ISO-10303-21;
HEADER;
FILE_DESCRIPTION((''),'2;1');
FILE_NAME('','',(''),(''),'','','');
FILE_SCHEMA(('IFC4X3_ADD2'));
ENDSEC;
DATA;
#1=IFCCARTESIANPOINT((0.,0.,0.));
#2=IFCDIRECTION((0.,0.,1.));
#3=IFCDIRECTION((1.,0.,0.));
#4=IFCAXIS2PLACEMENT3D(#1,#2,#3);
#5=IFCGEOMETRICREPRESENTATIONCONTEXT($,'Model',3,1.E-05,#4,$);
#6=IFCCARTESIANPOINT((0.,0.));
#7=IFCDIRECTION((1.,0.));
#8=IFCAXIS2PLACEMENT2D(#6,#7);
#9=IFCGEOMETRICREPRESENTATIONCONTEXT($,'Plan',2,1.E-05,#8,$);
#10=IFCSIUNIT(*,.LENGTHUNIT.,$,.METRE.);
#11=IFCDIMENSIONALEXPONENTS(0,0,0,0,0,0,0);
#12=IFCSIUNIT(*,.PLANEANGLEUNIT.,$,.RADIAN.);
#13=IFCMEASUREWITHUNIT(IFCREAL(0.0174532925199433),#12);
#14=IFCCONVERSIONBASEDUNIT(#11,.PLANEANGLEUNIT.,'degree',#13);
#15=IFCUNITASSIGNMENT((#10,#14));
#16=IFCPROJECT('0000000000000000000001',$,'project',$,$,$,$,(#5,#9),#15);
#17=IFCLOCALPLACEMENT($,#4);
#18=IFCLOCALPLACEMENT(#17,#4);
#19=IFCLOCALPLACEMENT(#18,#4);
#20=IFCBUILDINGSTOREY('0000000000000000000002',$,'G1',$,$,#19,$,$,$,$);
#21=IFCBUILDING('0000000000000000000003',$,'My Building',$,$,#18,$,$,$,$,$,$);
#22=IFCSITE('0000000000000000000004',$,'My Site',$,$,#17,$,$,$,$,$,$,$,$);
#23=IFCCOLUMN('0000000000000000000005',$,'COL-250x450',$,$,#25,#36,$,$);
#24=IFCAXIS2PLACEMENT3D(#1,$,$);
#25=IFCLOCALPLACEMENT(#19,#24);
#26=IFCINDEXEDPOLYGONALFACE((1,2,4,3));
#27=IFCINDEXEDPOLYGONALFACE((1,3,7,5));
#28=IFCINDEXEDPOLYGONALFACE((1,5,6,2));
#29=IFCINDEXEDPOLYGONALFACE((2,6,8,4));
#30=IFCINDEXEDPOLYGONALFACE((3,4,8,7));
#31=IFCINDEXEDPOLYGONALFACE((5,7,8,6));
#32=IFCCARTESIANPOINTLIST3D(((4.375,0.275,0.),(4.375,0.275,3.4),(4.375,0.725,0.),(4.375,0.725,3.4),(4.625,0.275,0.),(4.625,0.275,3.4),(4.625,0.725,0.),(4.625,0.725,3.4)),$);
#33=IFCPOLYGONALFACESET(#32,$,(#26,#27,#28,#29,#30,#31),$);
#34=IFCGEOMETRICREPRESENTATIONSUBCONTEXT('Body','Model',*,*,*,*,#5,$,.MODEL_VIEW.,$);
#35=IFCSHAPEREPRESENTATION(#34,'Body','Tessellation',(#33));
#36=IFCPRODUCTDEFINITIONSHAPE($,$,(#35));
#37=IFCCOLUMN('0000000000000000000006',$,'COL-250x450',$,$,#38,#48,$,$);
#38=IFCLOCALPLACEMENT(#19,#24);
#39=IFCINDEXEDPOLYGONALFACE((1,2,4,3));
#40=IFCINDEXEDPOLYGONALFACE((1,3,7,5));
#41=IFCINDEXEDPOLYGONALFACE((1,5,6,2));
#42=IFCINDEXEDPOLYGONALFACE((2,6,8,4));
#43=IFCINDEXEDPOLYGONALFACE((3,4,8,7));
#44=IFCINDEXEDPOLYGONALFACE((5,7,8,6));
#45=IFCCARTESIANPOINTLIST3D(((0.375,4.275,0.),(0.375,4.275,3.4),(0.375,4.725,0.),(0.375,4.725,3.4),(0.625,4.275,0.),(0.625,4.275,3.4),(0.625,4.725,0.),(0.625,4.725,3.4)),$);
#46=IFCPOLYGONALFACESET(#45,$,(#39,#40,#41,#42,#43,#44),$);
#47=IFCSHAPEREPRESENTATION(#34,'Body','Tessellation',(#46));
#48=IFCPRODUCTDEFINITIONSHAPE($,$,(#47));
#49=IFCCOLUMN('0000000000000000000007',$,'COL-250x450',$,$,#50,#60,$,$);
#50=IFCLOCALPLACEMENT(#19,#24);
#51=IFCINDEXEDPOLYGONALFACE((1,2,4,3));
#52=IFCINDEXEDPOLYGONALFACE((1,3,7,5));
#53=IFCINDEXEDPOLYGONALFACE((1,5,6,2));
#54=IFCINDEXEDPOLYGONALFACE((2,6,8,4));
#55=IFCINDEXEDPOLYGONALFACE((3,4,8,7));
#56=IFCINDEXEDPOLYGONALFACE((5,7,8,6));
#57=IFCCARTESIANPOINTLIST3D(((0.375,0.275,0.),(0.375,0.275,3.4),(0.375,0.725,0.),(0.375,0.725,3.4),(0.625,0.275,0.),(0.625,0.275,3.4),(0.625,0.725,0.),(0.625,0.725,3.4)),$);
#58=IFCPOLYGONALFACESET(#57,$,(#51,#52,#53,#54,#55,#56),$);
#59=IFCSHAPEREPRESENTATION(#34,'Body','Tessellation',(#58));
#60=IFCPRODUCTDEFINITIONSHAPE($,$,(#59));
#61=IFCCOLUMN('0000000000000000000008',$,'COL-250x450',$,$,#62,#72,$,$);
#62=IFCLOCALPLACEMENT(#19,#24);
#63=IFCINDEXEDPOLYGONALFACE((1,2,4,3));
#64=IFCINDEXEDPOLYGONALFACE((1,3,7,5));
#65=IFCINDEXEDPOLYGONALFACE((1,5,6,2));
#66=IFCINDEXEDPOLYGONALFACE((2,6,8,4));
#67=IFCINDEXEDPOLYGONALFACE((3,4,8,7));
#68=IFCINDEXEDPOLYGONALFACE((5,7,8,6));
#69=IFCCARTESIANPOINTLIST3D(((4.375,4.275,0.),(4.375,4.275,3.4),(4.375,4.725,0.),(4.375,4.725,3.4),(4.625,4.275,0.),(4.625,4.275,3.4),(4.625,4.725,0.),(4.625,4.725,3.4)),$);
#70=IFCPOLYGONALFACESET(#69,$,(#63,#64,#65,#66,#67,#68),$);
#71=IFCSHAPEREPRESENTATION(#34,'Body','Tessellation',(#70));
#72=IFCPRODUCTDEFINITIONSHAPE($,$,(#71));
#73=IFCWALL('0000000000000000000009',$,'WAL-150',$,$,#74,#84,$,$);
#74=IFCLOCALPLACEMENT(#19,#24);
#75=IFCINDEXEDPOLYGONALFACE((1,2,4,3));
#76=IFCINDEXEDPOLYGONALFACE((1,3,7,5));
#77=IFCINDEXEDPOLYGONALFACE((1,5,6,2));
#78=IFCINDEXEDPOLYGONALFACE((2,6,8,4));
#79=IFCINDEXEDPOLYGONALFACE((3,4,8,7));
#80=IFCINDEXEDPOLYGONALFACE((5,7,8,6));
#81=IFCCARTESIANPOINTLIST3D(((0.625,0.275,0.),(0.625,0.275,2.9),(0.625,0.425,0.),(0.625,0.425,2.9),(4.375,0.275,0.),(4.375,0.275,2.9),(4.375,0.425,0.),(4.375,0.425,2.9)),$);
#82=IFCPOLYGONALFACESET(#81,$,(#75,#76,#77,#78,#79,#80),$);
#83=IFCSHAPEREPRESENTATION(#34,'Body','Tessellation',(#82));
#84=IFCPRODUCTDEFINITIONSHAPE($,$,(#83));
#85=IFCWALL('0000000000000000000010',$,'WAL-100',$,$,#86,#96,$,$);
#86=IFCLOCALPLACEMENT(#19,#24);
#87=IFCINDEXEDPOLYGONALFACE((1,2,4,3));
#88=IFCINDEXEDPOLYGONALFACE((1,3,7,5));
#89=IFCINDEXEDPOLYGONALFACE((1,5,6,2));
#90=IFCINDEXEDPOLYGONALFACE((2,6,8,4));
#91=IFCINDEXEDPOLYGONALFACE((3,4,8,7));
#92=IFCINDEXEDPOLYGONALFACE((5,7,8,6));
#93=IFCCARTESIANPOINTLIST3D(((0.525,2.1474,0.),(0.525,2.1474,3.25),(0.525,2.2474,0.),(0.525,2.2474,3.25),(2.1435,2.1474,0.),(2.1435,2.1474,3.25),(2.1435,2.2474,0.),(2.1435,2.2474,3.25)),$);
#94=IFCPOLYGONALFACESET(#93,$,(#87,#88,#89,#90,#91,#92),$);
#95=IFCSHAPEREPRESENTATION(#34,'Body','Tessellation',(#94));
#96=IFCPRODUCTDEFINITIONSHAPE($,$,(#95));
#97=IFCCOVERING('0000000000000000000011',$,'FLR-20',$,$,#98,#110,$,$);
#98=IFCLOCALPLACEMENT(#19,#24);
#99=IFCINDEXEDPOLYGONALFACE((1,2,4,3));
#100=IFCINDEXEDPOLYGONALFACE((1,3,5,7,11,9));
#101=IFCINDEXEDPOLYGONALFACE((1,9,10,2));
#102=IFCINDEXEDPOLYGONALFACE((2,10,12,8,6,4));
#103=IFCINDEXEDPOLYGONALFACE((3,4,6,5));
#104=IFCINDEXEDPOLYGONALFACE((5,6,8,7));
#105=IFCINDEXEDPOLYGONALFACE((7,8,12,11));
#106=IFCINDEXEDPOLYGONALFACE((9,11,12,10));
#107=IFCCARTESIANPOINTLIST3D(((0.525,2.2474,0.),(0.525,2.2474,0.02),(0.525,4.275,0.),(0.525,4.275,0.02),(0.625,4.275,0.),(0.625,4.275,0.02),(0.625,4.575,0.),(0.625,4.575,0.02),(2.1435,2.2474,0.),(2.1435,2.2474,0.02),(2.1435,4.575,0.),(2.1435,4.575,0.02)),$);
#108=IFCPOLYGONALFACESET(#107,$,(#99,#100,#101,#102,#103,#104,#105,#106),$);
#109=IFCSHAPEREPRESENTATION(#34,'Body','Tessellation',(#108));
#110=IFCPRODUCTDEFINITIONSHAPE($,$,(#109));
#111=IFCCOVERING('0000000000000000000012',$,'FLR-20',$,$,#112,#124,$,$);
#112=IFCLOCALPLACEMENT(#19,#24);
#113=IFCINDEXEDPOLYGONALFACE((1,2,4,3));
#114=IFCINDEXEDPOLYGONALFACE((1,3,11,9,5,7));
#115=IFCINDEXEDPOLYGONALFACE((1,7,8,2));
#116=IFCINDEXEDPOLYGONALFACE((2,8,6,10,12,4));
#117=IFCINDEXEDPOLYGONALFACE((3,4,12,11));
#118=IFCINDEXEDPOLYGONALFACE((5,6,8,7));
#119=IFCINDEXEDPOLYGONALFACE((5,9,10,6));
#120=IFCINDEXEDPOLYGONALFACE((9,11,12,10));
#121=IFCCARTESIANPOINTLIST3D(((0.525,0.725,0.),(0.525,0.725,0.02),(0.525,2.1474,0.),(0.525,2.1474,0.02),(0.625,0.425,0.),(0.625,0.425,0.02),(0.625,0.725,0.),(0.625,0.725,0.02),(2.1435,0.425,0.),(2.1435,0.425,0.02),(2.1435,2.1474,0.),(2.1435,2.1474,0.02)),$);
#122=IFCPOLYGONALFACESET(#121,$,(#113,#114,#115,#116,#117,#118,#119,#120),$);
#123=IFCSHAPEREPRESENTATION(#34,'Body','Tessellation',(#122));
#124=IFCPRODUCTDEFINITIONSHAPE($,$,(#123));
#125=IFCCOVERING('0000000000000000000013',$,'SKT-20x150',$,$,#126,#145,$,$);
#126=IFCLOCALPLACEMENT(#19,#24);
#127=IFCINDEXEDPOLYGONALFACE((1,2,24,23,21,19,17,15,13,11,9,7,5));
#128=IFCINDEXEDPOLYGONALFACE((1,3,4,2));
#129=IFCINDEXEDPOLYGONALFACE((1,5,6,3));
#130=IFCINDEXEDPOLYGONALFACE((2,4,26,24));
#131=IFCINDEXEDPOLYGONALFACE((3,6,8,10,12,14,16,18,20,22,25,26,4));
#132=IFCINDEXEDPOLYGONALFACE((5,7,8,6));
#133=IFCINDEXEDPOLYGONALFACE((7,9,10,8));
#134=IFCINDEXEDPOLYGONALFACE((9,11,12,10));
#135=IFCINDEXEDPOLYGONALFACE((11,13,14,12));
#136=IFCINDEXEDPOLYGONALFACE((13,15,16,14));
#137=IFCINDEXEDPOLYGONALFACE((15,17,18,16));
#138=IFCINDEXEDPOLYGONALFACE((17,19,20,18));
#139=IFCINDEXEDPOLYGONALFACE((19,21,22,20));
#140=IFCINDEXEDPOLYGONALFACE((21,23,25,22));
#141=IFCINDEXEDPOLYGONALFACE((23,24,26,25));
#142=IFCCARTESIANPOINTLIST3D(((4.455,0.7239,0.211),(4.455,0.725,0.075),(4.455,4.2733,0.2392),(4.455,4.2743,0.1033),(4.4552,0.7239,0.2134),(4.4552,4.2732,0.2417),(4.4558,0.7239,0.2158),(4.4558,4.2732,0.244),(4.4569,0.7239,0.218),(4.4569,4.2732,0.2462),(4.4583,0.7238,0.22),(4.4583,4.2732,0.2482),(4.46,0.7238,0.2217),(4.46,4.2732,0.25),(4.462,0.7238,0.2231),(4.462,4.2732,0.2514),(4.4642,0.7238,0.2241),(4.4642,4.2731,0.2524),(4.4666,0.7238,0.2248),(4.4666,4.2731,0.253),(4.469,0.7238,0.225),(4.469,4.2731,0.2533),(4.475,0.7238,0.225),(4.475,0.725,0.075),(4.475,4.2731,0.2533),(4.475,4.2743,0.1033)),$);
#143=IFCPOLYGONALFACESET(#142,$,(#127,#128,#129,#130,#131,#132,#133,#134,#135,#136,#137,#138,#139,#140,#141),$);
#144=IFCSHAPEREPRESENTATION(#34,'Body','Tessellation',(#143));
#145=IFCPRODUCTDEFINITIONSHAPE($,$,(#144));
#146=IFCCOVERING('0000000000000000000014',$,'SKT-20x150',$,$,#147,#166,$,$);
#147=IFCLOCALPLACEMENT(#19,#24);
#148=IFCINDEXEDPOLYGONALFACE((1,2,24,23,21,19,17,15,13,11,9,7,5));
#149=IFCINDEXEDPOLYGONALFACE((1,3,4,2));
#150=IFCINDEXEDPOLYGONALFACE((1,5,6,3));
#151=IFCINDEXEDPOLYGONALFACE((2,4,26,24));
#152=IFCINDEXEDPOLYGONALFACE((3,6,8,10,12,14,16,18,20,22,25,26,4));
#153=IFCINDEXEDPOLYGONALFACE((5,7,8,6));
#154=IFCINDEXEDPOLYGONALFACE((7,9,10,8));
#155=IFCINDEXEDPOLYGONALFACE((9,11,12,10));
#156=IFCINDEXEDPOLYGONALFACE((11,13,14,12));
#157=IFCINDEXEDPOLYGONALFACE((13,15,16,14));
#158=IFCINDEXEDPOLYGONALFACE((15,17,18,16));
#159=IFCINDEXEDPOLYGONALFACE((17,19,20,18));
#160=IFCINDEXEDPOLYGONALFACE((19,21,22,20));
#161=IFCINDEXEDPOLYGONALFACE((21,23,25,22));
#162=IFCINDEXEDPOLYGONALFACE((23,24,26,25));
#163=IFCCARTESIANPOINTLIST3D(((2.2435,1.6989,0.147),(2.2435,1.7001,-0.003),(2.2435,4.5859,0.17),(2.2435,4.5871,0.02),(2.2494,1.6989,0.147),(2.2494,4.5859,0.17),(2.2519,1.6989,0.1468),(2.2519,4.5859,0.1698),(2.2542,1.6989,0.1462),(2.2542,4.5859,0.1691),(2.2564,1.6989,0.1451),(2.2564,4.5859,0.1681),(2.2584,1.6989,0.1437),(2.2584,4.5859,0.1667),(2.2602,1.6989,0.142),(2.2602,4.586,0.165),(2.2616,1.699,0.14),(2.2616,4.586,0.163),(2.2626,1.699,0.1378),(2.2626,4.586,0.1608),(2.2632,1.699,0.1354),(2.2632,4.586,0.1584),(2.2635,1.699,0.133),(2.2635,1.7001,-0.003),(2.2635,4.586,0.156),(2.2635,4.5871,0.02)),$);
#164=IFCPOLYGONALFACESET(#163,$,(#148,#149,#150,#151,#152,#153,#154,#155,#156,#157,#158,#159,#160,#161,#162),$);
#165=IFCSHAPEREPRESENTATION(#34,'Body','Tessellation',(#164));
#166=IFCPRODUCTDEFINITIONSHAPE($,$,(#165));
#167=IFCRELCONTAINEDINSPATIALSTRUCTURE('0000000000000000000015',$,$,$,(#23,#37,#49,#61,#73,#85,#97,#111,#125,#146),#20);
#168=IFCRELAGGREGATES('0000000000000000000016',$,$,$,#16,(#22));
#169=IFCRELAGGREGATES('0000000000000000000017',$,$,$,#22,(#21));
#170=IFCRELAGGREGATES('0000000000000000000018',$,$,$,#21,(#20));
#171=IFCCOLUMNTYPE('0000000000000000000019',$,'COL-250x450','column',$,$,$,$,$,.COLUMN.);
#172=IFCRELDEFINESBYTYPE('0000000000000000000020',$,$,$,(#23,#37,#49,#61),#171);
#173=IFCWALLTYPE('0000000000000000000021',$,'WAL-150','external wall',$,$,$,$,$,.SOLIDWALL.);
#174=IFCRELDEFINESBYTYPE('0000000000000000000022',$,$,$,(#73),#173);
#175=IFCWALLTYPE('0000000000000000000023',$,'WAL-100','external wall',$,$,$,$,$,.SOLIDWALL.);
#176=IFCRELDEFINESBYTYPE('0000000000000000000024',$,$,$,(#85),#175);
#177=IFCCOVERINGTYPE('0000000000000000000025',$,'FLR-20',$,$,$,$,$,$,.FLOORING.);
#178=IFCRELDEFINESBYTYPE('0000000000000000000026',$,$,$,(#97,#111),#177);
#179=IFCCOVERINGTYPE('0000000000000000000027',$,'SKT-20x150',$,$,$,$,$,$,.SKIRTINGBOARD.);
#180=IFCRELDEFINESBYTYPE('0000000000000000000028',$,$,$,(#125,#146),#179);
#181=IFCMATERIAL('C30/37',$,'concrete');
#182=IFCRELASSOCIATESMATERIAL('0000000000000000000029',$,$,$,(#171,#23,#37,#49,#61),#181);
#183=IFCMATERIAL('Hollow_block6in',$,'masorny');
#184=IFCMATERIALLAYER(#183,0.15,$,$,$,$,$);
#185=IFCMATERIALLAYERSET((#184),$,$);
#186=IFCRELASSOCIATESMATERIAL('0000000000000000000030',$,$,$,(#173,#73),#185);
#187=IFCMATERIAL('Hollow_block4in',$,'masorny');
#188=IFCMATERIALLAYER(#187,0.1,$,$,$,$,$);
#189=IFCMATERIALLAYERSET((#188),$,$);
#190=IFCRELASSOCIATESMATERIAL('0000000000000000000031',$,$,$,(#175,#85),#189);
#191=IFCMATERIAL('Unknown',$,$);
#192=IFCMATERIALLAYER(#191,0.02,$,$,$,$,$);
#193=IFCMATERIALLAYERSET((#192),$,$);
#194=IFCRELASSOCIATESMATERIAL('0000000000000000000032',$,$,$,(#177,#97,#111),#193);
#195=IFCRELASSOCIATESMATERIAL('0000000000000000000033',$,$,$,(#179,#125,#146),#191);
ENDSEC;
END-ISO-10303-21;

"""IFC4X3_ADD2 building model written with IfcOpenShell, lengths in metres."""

from ifc_helpers import new_model, entity, si_unit, converted_unit, frame, origin_with_axes, origin_2d_with_axis, place, context, subcontext, project, spatial, line, indexed_curve, rectangle, outline, extrude, material, layer, layer_set, layer_usage, material_profile, profile_set, profile_usage, type_object, element, save


model = new_model("IFC4X3_ADD2")

# Units and contexts
model_context = context("Model", 3, precision=1e-05, world=origin_with_axes())
plan_context = context("Plan", 2, precision=1e-05, world=origin_2d_with_axis())
body_context = subcontext(model_context, "Body", "Model", "MODEL_VIEW")
ifc_project = project(units=[si_unit("LENGTHUNIT", "METRE"), converted_unit("PLANEANGLEUNIT", "degree", entity("IfcReal", 0.0174532925199433), si_unit("PLANEANGLEUNIT", "RADIAN"), dimensions=[0, 0, 0, 0, 0, 0, 0])], contexts=[model_context, plan_context])

# Site, building, storey
site_placement = place(None, origin_with_axes())
site = spatial("IfcSite", under=ifc_project, at=site_placement, Name="My Site")
building_placement = place(site_placement, origin_with_axes())
building = spatial("IfcBuilding", under=site, at=building_placement, Name="My Building")
storey_placement = place(building_placement, origin_with_axes())
storey = spatial("IfcBuildingStorey", under=building, at=storey_placement, Name="G1")

# Columns
ifc_material_1 = material(Name="C30/37", Category="concrete")
ifc_material_profile_1 = material_profile(ifc_material_1, rectangle(XDim=0.25, YDim=0.45))
ifc_profile_set_1 = profile_set([ifc_material_profile_1])
ifc_profile_usage_1 = profile_usage(ifc_profile_set_1, cardinal=2)
column_type = type_object("IfcColumnType", Name="COL-250x450", Description="column", PredefinedType="COLUMN", material=ifc_profile_set_1)
column_1_placement = place(storey_placement, frame((4.5, 0.275, 0.0), z_axis=(0.0, 0.0, 1.0), x_axis=(1.0, 0.0, 0.0)))
element("IfcColumn", 1, at=column_1_placement, inside=storey, type_object=column_type, material=ifc_profile_usage_1, Name="COL-250x450", context=body_context, shape_type="SweptSolid", body=[
    extrude(rectangle(XDim=0.25, YDim=0.45), frame((0.0, 0.225, 0.0), z_axis=(0.0, 0.0, 1.0), x_axis=(1.0, 0.0, 0.0)), (0.0, 0.0, 1.0), 3.4),
])
ifc_profile_usage_2 = profile_usage(ifc_profile_set_1, cardinal=2)
column_2_placement = place(storey_placement, frame((0.5, 4.275, 0.0), z_axis=(0.0, 0.0, 1.0), x_axis=(1.0, 0.0, 0.0)))
element("IfcColumn", 2, at=column_2_placement, inside=storey, type_object=column_type, material=ifc_profile_usage_2, Name="COL-250x450", context=body_context, shape_type="SweptSolid", body=[
    extrude(rectangle(XDim=0.25, YDim=0.45), frame((0.0, 0.225, 0.0), z_axis=(0.0, 0.0, 1.0), x_axis=(1.0, 0.0, 0.0)), (0.0, 0.0, 1.0), 3.4),
])
ifc_profile_usage_3 = profile_usage(ifc_profile_set_1, cardinal=2)
column_3_placement = place(storey_placement, frame((0.5, 0.275, 0.0), z_axis=(0.0, 0.0, 1.0), x_axis=(1.0, 0.0, 0.0)))
element("IfcColumn", 3, at=column_3_placement, inside=storey, type_object=column_type, material=ifc_profile_usage_3, Name="COL-250x450", context=body_context, shape_type="SweptSolid", body=[
    extrude(rectangle(XDim=0.25, YDim=0.45), frame((0.0, 0.225, 0.0), z_axis=(0.0, 0.0, 1.0), x_axis=(1.0, 0.0, 0.0)), (0.0, 0.0, 1.0), 3.4),
])
ifc_profile_usage_4 = profile_usage(ifc_profile_set_1, cardinal=2)
column_4_placement = place(storey_placement, frame((4.5, 4.275, 0.0), z_axis=(0.0, 0.0, 1.0), x_axis=(1.0, 0.0, 0.0)))
element("IfcColumn", 4, at=column_4_placement, inside=storey, type_object=column_type, material=ifc_profile_usage_4, Name="COL-250x450", context=body_context, shape_type="SweptSolid", body=[
    extrude(rectangle(XDim=0.25, YDim=0.45), frame((0.0, 0.225, 0.0), z_axis=(0.0, 0.0, 1.0), x_axis=(1.0, 0.0, 0.0)), (0.0, 0.0, 1.0), 3.4),
])

# Walls
ifc_material_2 = material(Name="Hollow_block6in", Category="masorny")
ifc_layer_1 = layer(ifc_material_2, 0.15)
ifc_layer_set_1 = layer_set([ifc_layer_1])
ifc_layer_usage_1 = layer_usage(ifc_layer_set_1, "AXIS2", "POSITIVE", 0.0)
wall_type_1 = type_object("IfcWallType", Name="WAL-150", Description="external wall", PredefinedType="SOLIDWALL", material=ifc_layer_set_1)
wall_1_placement = place(storey_placement, frame((0.625, 0.275, 0.0), z_axis=(0.0, 0.0, 1.0), x_axis=(1.0, 0.0, 0.0)))
element("IfcWall", 5, at=wall_1_placement, inside=storey, type_object=wall_type_1, material=ifc_layer_usage_1, Name="WAL-150", context=body_context, shape_type="SweptSolid", body=[
    extrude(outline(indexed_curve([(0.0, 0.0), (0.0, 0.15), (3.75, 0.15), (3.75, 0.0)], segments=[line(1, 2, 3, 4, 1)])), origin_with_axes(), (0.0, 0.0, 1.0), 2.9),
])
ifc_material_3 = material(Name="Hollow_block4in", Category="masorny")
ifc_layer_2 = layer(ifc_material_3, 0.1)
ifc_layer_set_2 = layer_set([ifc_layer_2])
ifc_layer_usage_2 = layer_usage(ifc_layer_set_2, "AXIS2", "POSITIVE", 0.0)
wall_type_2 = type_object("IfcWallType", Name="WAL-100", Description="external wall", PredefinedType="SOLIDWALL", material=ifc_layer_set_2)
wall_2_placement = place(storey_placement, frame((2.1435, 2.2474, 0.0), z_axis=(0.0, 0.0, 1.0), x_axis=(-1.0, 0.0, 0.0)))
element("IfcWall", 6, at=wall_2_placement, inside=storey, type_object=wall_type_2, material=ifc_layer_usage_2, Name="WAL-100", context=body_context, shape_type="SweptSolid", body=[
    extrude(outline(indexed_curve([(0.0, 0.0), (0.0, 0.1), (1.6185, 0.1), (1.6185, 0.0)], segments=[line(1, 2, 3, 4, 1)])), origin_with_axes(), (0.0, 0.0, 1.0), 3.25),
])

# Coverings
ifc_material_4 = material(Name="Unknown")
ifc_layer_3 = layer(ifc_material_4, 0.02)
ifc_layer_set_3 = layer_set([ifc_layer_3])
covering_type_1 = type_object("IfcCoveringType", Name="FLR-20", PredefinedType="FLOORING", material=ifc_layer_set_3)
ifc_layer_usage_3 = layer_usage(ifc_layer_set_3, "AXIS3", "POSITIVE", 0.0)
covering_1_placement = place(storey_placement, frame((0.525, 2.2474, 0.0), z_axis=(0.0, 0.0, 1.0), x_axis=(1.0, 0.0, 0.0)))
element("IfcCovering", 7, at=covering_1_placement, inside=storey, type_object=covering_type_1, material=ifc_layer_usage_3, Name="FLR-20", context=body_context, shape_type="SweptSolid", body=[
    extrude(outline(indexed_curve([(0.0, 2.0276), (0.0, 0.0), (1.6185, 0.0), (1.6185, 2.3276), (0.1, 2.3276), (0.1, 2.0276), (0.0, 2.0276)])), None, (0.0, 0.0, 1.0), 0.02),
])
ifc_layer_usage_4 = layer_usage(ifc_layer_set_3, "AXIS3", "POSITIVE", 0.0)
covering_2_placement = place(storey_placement, frame((0.525, 0.425, 0.0), z_axis=(0.0, 0.0, 1.0), x_axis=(1.0, 0.0, 0.0)))
element("IfcCovering", 8, at=covering_2_placement, inside=storey, type_object=covering_type_1, material=ifc_layer_usage_4, Name="FLR-20", context=body_context, shape_type="SweptSolid", body=[
    extrude(outline(indexed_curve([(0.0, 0.3), (0.0, 1.7224), (1.6185, 1.7224), (1.6185, 0.0), (0.1, 0.0), (0.1, 0.3), (0.0, 0.3)])), None, (0.0, 0.0, 1.0), 0.02),
])
ifc_material_profile_2 = material_profile(ifc_material_4, outline(indexed_curve([(0.0, 0.0), (0.02, 0.0), (0.02, 0.136), (0.0198, 0.1384), (0.0192, 0.1408), (0.0181, 0.143), (0.0167, 0.145), (0.015, 0.1467), (0.013, 0.1481), (0.0108, 0.1492), (0.0084, 0.1498), (0.006, 0.15), (0.0, 0.15), (0.0, 0.0)])))
ifc_profile_set_2 = profile_set([ifc_material_profile_2])
ifc_profile_usage_5 = profile_usage(ifc_profile_set_2, cardinal=1)
covering_type_2 = type_object("IfcCoveringType", Name="SKT-20x150", PredefinedType="SKIRTINGBOARD", material=ifc_profile_set_2)
covering_3_placement = place(storey_placement, frame((4.465, 0.7256, 0.0), z_axis=(0.0, 0.999968, 0.007961), x_axis=(-1.0, 0.0, 0.0)))
element("IfcCovering", 9, at=covering_3_placement, inside=storey, type_object=covering_type_2, material=ifc_profile_usage_5, Name="SKT-20x150", context=body_context, shape_type="SweptSolid", body=[
    extrude(outline(indexed_curve([(0.0, 0.0), (0.02, 0.0), (0.02, 0.136), (0.0198, 0.1384), (0.0192, 0.1408), (0.0181, 0.143), (0.0167, 0.145), (0.015, 0.1467), (0.013, 0.1481), (0.0108, 0.1492), (0.0084, 0.1498), (0.006, 0.15), (0.0, 0.15), (0.0, 0.0)])), frame((-0.01, 0.075, 0.0), z_axis=(0.0, 0.0, 1.0), x_axis=(1.0, 0.0, 0.0)), (0.0, 0.0, 1.0), 3.5494),
])
ifc_profile_usage_6 = profile_usage(ifc_profile_set_2, cardinal=1)
covering_4_placement = place(storey_placement, frame((2.2535, 4.5877, -0.055), z_axis=(0.0, -0.999968, -0.007961), x_axis=(1.0, 0.0, 0.0)))
element("IfcCovering", 10, at=covering_4_placement, inside=storey, type_object=covering_type_2, material=ifc_profile_usage_6, Name="SKT-20x150", context=body_context, shape_type="SweptSolid", body=[
    extrude(outline(indexed_curve([(0.0, 0.0), (0.02, 0.0), (0.02, 0.136), (0.0198, 0.1384), (0.0192, 0.1408), (0.0181, 0.143), (0.0167, 0.145), (0.015, 0.1467), (0.013, 0.1481), (0.0108, 0.1492), (0.0084, 0.1498), (0.006, 0.15), (0.0, 0.15), (0.0, 0.0)])), frame((-0.01, 0.075, 0.0), z_axis=(0.0, 0.0, 1.0), x_axis=(1.0, 0.0, 0.0)), (0.0, 0.0, 1.0), 2.8871),
])

save(model, "model.ifc")
